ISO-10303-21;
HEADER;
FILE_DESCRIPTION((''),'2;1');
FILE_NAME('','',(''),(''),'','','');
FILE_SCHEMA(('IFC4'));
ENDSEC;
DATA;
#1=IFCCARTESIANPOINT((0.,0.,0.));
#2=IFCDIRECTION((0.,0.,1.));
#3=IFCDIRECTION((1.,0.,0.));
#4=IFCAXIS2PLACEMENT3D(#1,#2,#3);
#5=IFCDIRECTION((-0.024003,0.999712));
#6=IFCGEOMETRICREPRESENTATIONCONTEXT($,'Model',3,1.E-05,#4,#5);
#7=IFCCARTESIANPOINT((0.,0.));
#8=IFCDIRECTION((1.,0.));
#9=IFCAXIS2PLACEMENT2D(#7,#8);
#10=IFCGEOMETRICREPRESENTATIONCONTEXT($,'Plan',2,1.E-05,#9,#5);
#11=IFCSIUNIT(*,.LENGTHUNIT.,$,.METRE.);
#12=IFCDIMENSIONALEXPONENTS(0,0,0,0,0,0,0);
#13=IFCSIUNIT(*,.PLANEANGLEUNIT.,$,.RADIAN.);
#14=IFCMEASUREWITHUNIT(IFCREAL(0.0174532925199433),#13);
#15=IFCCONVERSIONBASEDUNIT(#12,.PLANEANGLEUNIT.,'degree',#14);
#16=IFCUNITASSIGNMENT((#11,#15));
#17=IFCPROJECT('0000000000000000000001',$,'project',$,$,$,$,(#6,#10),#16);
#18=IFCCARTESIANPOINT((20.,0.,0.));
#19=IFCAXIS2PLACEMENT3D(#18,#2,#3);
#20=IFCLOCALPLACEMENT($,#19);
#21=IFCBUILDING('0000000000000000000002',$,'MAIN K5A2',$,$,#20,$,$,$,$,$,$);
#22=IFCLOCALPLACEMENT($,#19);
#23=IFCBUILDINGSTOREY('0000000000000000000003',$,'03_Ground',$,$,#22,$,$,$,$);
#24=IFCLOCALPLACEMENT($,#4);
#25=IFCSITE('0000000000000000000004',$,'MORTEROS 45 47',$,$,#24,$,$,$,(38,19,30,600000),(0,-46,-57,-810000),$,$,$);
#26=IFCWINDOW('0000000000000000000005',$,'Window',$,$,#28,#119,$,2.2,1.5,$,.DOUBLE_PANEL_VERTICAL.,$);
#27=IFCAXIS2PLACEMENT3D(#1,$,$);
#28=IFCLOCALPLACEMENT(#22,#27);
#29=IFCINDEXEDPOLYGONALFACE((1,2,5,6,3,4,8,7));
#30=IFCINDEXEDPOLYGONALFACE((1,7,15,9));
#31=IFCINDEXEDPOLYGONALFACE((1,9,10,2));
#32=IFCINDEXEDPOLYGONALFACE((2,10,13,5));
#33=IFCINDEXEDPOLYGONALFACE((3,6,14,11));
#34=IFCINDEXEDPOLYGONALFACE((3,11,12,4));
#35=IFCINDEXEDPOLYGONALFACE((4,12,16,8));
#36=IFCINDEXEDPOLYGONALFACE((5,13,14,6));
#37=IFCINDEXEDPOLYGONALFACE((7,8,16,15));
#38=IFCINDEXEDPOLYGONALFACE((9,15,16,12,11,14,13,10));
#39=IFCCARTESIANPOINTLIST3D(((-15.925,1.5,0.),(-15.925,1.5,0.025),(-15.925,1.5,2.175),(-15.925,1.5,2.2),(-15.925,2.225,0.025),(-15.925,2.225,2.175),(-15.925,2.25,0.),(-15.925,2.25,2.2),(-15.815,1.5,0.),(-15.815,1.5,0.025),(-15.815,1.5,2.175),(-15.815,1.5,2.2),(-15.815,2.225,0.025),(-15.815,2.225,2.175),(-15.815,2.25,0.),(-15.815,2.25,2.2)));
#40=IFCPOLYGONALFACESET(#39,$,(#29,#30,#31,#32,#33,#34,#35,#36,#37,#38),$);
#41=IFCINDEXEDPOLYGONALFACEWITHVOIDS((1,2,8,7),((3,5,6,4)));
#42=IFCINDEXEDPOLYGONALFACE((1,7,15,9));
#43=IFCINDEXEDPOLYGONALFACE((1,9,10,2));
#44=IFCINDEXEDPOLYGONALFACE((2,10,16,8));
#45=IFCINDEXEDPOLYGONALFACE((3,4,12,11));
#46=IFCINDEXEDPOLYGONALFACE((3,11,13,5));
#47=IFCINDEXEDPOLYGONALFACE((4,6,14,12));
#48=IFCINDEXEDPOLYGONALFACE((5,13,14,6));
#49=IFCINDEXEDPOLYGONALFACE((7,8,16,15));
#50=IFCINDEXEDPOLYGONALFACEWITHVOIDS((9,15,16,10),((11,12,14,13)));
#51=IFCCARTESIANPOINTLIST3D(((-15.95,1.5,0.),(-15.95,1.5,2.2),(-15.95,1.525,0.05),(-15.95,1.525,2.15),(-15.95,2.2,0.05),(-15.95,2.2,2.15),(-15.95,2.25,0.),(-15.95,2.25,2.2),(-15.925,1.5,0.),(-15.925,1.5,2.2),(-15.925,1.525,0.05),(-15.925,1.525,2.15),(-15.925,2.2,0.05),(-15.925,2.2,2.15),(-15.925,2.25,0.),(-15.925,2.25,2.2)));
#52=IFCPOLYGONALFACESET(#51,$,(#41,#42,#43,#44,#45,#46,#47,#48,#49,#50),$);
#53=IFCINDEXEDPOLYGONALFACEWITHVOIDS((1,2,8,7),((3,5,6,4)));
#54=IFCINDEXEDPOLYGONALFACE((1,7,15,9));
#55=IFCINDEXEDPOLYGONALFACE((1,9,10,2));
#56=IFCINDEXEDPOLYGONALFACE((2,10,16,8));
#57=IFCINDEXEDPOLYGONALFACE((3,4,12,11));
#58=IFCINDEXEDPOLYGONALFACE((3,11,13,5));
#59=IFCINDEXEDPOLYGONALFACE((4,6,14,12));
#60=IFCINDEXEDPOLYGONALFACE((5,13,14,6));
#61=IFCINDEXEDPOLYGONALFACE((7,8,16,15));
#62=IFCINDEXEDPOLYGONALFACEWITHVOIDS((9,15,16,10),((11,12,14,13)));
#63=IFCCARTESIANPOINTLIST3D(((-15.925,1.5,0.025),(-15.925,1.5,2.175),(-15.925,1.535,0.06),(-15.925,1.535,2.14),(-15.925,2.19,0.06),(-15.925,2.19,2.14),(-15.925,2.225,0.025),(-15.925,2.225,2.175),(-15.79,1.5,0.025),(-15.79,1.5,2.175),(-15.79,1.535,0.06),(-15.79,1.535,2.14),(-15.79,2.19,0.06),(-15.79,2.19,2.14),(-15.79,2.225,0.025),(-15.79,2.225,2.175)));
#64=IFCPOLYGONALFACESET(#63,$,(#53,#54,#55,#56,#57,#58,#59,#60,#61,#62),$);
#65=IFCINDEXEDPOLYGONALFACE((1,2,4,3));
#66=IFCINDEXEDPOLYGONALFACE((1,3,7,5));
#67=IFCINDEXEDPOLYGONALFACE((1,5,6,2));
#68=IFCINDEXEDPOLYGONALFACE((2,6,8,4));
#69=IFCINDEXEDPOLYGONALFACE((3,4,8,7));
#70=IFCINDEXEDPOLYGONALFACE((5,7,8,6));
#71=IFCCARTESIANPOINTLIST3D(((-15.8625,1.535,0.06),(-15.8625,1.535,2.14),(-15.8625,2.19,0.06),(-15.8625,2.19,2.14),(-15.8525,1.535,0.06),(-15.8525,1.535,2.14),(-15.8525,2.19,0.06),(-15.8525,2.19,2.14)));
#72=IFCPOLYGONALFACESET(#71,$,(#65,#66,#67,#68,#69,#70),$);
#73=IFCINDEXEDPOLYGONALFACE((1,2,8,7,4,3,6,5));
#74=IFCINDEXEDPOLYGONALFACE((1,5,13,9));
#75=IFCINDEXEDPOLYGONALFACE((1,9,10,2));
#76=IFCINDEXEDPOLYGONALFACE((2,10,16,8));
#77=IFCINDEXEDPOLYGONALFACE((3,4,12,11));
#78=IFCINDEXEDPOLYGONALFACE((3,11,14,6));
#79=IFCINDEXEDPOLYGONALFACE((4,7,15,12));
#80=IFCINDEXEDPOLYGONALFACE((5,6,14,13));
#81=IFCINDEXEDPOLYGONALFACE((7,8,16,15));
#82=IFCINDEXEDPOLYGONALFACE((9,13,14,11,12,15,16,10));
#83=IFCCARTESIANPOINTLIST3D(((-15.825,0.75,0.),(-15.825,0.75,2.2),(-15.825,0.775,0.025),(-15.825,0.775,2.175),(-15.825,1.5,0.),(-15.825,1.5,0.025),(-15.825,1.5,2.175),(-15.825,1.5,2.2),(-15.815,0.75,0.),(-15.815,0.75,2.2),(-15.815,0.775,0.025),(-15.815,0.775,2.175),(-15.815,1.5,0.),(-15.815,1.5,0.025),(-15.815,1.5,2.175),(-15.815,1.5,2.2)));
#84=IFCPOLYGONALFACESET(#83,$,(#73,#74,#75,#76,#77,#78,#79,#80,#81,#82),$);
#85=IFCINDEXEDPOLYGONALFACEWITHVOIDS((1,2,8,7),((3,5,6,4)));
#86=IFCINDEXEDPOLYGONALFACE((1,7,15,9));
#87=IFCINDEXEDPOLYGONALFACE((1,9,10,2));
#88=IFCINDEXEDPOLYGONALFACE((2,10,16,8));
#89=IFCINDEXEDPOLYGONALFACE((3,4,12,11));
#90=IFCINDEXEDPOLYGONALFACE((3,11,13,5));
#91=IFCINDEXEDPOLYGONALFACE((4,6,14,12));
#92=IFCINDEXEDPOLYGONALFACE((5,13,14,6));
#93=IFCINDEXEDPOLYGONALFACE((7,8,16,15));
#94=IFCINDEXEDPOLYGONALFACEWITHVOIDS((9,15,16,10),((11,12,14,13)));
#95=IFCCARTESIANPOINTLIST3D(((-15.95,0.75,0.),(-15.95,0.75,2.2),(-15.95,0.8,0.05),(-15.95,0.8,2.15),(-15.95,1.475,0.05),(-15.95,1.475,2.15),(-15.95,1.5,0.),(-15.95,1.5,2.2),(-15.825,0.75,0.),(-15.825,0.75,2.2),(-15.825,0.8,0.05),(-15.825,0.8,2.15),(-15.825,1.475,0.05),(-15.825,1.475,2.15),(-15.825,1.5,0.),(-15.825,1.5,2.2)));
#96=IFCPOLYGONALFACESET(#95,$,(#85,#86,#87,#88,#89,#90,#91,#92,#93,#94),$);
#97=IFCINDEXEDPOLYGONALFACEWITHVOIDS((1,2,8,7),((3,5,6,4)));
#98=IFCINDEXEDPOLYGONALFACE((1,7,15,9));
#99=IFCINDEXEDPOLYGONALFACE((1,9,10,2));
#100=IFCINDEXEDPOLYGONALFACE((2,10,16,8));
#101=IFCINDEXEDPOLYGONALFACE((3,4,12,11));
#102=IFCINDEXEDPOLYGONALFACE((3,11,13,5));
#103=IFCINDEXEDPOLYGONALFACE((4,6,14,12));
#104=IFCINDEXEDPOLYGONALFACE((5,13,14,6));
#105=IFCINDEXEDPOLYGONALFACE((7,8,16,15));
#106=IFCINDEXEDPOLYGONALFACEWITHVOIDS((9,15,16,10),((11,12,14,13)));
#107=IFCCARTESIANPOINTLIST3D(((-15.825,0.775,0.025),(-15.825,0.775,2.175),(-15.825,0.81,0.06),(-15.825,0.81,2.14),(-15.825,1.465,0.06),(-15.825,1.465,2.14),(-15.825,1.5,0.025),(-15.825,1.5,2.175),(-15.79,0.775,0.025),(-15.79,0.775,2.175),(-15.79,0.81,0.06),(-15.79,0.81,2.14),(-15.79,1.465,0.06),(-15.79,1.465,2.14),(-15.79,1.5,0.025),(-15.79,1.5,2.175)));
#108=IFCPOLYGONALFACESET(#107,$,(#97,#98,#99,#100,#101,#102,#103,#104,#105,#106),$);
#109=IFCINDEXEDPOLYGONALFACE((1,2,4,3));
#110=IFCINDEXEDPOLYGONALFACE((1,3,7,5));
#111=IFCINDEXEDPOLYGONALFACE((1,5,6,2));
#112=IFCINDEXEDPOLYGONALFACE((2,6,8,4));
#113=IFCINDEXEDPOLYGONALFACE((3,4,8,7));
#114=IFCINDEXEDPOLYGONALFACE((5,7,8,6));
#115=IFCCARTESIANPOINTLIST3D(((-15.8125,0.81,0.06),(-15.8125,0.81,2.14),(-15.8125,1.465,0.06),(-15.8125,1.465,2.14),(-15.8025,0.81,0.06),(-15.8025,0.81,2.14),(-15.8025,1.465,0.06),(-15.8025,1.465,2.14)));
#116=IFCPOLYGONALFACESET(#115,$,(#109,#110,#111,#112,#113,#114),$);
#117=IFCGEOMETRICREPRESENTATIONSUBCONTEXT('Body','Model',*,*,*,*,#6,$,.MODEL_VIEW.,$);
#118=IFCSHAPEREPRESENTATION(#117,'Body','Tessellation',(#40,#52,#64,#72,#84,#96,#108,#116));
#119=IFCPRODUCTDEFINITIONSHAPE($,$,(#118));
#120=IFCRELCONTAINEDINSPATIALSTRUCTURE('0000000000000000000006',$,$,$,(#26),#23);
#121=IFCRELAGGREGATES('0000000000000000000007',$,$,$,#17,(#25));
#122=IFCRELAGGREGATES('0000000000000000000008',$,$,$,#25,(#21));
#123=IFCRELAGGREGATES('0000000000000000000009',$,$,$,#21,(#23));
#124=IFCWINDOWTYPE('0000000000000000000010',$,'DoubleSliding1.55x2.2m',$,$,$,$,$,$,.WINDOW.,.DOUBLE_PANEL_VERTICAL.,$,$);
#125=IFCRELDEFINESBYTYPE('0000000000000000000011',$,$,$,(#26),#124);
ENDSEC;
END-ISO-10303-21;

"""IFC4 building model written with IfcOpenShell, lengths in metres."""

from ifc_helpers import new_model, entity, si_unit, converted_unit, direction, frame, origin_with_axes, origin_2d_with_axis, place, context, subcontext, project, spatial, line, indexed_curve, outline, extrude, shape, source, transform, mapped, type_object, element, save


model = new_model("IFC4")

# Units and contexts
model_context = context("Model", 3, precision=1e-05, world=origin_with_axes(), true_north=direction((-0.024003, 0.999712)))
plan_context = context("Plan", 2, precision=1e-05, world=origin_2d_with_axis(), true_north=direction((-0.024003, 0.999712)))
body_context_1 = subcontext(model_context, "Body", "Model", "MODEL_VIEW")
body_context_2 = subcontext(plan_context, "Body", "Plan", "PLAN_VIEW")
ifc_project = project(units=[si_unit("LENGTHUNIT", "METRE"), converted_unit("PLANEANGLEUNIT", "degree", entity("IfcReal", 0.0174532925199433), si_unit("PLANEANGLEUNIT", "RADIAN"), dimensions=[0, 0, 0, 0, 0, 0, 0])], contexts=[model_context, plan_context])

# Site, building, storey
site_placement = place(None, origin_with_axes())
site = spatial("IfcSite", under=ifc_project, at=site_placement, Name="MORTEROS 45 47", RefLatitude=(38, 19, 30, 600000), RefLongitude=(0, -46, -57, -810000))
building_placement = place(None, frame((20.0, 0.0, 0.0), z_axis=(0.0, 0.0, 1.0), x_axis=(1.0, 0.0, 0.0)))
building = spatial("IfcBuilding", under=site, at=building_placement, Name="MAIN K5A2")
storey_placement = place(None, frame((20.0, 0.0, 0.0), z_axis=(0.0, 0.0, 1.0), x_axis=(1.0, 0.0, 0.0)))
storey = spatial("IfcBuildingStorey", under=building, at=storey_placement, Name="03_Ground")

# Window
window_type = type_object("IfcWindowType", Name="DoubleSliding1.55x2.2m", PartitioningType="DOUBLE_PANEL_VERTICAL", PredefinedType="WINDOW")
shared_shape_1 = source(origin_with_axes(), body_context_1, "Body", "SolidModel", [
    extrude(outline(indexed_curve([(0.75, 0.0), (0.0, 0.0), (0.0, 2.2), (0.75, 2.2), (0.75, 2.175), (0.025, 2.175), (0.025, 0.025), (0.75, 0.025)], segments=[line(1, 2, 3, 4, 5, 6, 7, 8, 1)])), frame((0.0, 0.075, 0.0), z_axis=(0.0, -1.0, 0.0), x_axis=(1.0, 0.0, 0.0)), (0.0, 0.0, -1.0), 0.11),
    extrude(outline(indexed_curve([(0.0, 0.0), (0.75, 0.0), (0.75, 2.2), (0.0, 2.2)], segments=[line(1, 2, 3, 4, 1)]), holes=[indexed_curve([(0.05, 0.05), (0.725, 0.05), (0.725, 2.15), (0.05, 2.15)], segments=[line(1, 2, 3, 4, 1)])]), frame((0.0, 0.05, 0.0), z_axis=(0.0, -1.0, 0.0), x_axis=(1.0, 0.0, 0.0)), (0.0, 0.0, -1.0), 0.025),
    extrude(outline(indexed_curve([(0.0, 0.0), (0.725, 0.0), (0.725, 2.15), (0.0, 2.15)], segments=[line(1, 2, 3, 4, 1)]), holes=[indexed_curve([(0.035, 0.035), (0.69, 0.035), (0.69, 2.115), (0.035, 2.115)], segments=[line(1, 2, 3, 4, 1)])]), frame((0.025, 0.075, 0.025), z_axis=(0.0, -1.0, 0.0), x_axis=(1.0, 0.0, 0.0)), (0.0, 0.0, -1.0), 0.135),
    extrude(outline(indexed_curve([(0.035, 0.035), (0.69, 0.035), (0.69, 2.115), (0.035, 2.115)], segments=[line(1, 2, 3, 4, 1)])), frame((0.025, 0.1375, 0.025), z_axis=(0.0, -1.0, 0.0), x_axis=(1.0, 0.0, 0.0)), (0.0, 0.0, -1.0), 0.01),
    extrude(outline(indexed_curve([(0.0, 2.2), (0.75, 2.2), (0.75, 0.0), (0.0, 0.0), (0.0, 0.025), (0.725, 0.025), (0.725, 2.175), (0.0, 2.175)], segments=[line(1, 2, 3, 4, 5, 6, 7, 8, 1)])), frame((0.75, 0.175, 0.0), z_axis=(0.0, -1.0, 0.0), x_axis=(1.0, 0.0, 0.0)), (0.0, 0.0, -1.0), 0.01),
    extrude(outline(indexed_curve([(0.0, 0.0), (0.75, 0.0), (0.75, 2.2), (0.0, 2.2)], segments=[line(1, 2, 3, 4, 1)]), holes=[indexed_curve([(0.025, 0.05), (0.7, 0.05), (0.7, 2.15), (0.025, 2.15)], segments=[line(1, 2, 3, 4, 1)])]), frame((0.75, 0.05, 0.0), z_axis=(0.0, -1.0, 0.0), x_axis=(1.0, 0.0, 0.0)), (0.0, 0.0, -1.0), 0.125),
    extrude(outline(indexed_curve([(0.0, 0.0), (0.725, 0.0), (0.725, 2.15), (0.0, 2.15)], segments=[line(1, 2, 3, 4, 1)]), holes=[indexed_curve([(0.035, 0.035), (0.69, 0.035), (0.69, 2.115), (0.035, 2.115)], segments=[line(1, 2, 3, 4, 1)])]), frame((0.75, 0.175, 0.025), z_axis=(0.0, -1.0, 0.0), x_axis=(1.0, 0.0, 0.0)), (0.0, 0.0, -1.0), 0.035),
    extrude(outline(indexed_curve([(0.035, 0.035), (0.69, 0.035), (0.69, 2.115), (0.035, 2.115)], segments=[line(1, 2, 3, 4, 1)])), frame((0.75, 0.1875, 0.025), z_axis=(0.0, -1.0, 0.0), x_axis=(1.0, 0.0, 0.0)), (0.0, 0.0, -1.0), 0.01),
])
shared_shape_2 = source(origin_with_axes(), body_context_2, "Body", "Curve2D", [
    entity("IfcIndexedPolyCurve", entity("IfcCartesianPointList2D", [[0.05, 0.05], [0.725, 0.05]])),
    entity("IfcIndexedPolyCurve", entity("IfcCartesianPointList2D", [[0.0, 0.185], [0.025, 0.185], [0.025, 0.075], [0.05, 0.075], [0.05, 0.05], [0.0, 0.05]]), [entity("IfcLineIndex", [1, 2, 3, 4, 5, 6, 1])]),
    entity("IfcIndexedPolyCurve", entity("IfcCartesianPointList2D", [[0.75, 0.185], [0.75, 0.185], [0.75, 0.075], [0.725, 0.075], [0.725, 0.05], [0.75, 0.05]])),
    entity("IfcIndexedPolyCurve", entity("IfcCartesianPointList2D", [[0.025, 0.075], [0.06, 0.075], [0.06, 0.21], [0.025, 0.21]]), [entity("IfcLineIndex", [1, 2, 3, 4, 1])]),
    entity("IfcIndexedPolyCurve", entity("IfcCartesianPointList2D", [[0.75, 0.075], [0.715, 0.075], [0.715, 0.21], [0.75, 0.21]]), [entity("IfcLineIndex", [1, 2, 3, 4, 1])]),
    entity("IfcIndexedPolyCurve", entity("IfcCartesianPointList2D", [[0.06, 0.075], [0.715, 0.075]])),
    entity("IfcIndexedPolyCurve", entity("IfcCartesianPointList2D", [[0.06, 0.21], [0.715, 0.21]])),
    entity("IfcIndexedPolyCurve", entity("IfcCartesianPointList2D", [[0.06, 0.1425], [0.715, 0.1425]])),
    entity("IfcIndexedPolyCurve", entity("IfcCartesianPointList2D", [[0.775, 0.05], [1.45, 0.05]])),
    entity("IfcIndexedPolyCurve", entity("IfcCartesianPointList2D", [[0.75, 0.185], [0.75, 0.185], [0.75, 0.175], [0.775, 0.175], [0.775, 0.05], [0.75, 0.05]])),
    entity("IfcIndexedPolyCurve", entity("IfcCartesianPointList2D", [[1.5, 0.185], [1.475, 0.185], [1.475, 0.175], [1.45, 0.175], [1.45, 0.05], [1.5, 0.05]]), [entity("IfcLineIndex", [1, 2, 3, 4, 5, 6, 1])]),
    entity("IfcIndexedPolyCurve", entity("IfcCartesianPointList2D", [[0.75, 0.175], [0.785, 0.175], [0.785, 0.21], [0.75, 0.21]]), [entity("IfcLineIndex", [1, 2, 3, 4, 1])]),
    entity("IfcIndexedPolyCurve", entity("IfcCartesianPointList2D", [[1.475, 0.175], [1.44, 0.175], [1.44, 0.21], [1.475, 0.21]]), [entity("IfcLineIndex", [1, 2, 3, 4, 1])]),
    entity("IfcIndexedPolyCurve", entity("IfcCartesianPointList2D", [[0.785, 0.175], [1.44, 0.175]])),
    entity("IfcIndexedPolyCurve", entity("IfcCartesianPointList2D", [[0.785, 0.21], [1.44, 0.21]])),
    entity("IfcIndexedPolyCurve", entity("IfcCartesianPointList2D", [[0.785, 0.1925], [1.44, 0.1925]])),
])
window_1_placement = place(None, frame((4.0, 2.25, 0.0), z_axis=(0.0, 0.0, 1.0), x_axis=(0.0, -1.0, 0.0)))
element("IfcWindow", 1, at=window_1_placement, inside=storey, type_object=window_type, Name="Window", OverallHeight=2.2, OverallWidth=1.5, PartitioningType="DOUBLE_PANEL_VERTICAL", shapes=[
    shape(body_context_1, "Body", "MappedRepresentation", [mapped(shared_shape_1, transform((0.0, 0.0, 0.0), x_axis=(1.0, 0.0, 0.0), y_axis=(0.0, 1.0, 0.0), z_axis=(0.0, 0.0, 1.0), scale=1.0))]),
    shape(body_context_2, "Body", "MappedRepresentation", [mapped(shared_shape_2, transform((0.0, 0.0, 0.0), x_axis=(1.0, 0.0, 0.0), y_axis=(0.0, 1.0, 0.0), z_axis=(0.0, 0.0, 1.0), scale=1.0))]),
])

save(model, "model.ifc")
